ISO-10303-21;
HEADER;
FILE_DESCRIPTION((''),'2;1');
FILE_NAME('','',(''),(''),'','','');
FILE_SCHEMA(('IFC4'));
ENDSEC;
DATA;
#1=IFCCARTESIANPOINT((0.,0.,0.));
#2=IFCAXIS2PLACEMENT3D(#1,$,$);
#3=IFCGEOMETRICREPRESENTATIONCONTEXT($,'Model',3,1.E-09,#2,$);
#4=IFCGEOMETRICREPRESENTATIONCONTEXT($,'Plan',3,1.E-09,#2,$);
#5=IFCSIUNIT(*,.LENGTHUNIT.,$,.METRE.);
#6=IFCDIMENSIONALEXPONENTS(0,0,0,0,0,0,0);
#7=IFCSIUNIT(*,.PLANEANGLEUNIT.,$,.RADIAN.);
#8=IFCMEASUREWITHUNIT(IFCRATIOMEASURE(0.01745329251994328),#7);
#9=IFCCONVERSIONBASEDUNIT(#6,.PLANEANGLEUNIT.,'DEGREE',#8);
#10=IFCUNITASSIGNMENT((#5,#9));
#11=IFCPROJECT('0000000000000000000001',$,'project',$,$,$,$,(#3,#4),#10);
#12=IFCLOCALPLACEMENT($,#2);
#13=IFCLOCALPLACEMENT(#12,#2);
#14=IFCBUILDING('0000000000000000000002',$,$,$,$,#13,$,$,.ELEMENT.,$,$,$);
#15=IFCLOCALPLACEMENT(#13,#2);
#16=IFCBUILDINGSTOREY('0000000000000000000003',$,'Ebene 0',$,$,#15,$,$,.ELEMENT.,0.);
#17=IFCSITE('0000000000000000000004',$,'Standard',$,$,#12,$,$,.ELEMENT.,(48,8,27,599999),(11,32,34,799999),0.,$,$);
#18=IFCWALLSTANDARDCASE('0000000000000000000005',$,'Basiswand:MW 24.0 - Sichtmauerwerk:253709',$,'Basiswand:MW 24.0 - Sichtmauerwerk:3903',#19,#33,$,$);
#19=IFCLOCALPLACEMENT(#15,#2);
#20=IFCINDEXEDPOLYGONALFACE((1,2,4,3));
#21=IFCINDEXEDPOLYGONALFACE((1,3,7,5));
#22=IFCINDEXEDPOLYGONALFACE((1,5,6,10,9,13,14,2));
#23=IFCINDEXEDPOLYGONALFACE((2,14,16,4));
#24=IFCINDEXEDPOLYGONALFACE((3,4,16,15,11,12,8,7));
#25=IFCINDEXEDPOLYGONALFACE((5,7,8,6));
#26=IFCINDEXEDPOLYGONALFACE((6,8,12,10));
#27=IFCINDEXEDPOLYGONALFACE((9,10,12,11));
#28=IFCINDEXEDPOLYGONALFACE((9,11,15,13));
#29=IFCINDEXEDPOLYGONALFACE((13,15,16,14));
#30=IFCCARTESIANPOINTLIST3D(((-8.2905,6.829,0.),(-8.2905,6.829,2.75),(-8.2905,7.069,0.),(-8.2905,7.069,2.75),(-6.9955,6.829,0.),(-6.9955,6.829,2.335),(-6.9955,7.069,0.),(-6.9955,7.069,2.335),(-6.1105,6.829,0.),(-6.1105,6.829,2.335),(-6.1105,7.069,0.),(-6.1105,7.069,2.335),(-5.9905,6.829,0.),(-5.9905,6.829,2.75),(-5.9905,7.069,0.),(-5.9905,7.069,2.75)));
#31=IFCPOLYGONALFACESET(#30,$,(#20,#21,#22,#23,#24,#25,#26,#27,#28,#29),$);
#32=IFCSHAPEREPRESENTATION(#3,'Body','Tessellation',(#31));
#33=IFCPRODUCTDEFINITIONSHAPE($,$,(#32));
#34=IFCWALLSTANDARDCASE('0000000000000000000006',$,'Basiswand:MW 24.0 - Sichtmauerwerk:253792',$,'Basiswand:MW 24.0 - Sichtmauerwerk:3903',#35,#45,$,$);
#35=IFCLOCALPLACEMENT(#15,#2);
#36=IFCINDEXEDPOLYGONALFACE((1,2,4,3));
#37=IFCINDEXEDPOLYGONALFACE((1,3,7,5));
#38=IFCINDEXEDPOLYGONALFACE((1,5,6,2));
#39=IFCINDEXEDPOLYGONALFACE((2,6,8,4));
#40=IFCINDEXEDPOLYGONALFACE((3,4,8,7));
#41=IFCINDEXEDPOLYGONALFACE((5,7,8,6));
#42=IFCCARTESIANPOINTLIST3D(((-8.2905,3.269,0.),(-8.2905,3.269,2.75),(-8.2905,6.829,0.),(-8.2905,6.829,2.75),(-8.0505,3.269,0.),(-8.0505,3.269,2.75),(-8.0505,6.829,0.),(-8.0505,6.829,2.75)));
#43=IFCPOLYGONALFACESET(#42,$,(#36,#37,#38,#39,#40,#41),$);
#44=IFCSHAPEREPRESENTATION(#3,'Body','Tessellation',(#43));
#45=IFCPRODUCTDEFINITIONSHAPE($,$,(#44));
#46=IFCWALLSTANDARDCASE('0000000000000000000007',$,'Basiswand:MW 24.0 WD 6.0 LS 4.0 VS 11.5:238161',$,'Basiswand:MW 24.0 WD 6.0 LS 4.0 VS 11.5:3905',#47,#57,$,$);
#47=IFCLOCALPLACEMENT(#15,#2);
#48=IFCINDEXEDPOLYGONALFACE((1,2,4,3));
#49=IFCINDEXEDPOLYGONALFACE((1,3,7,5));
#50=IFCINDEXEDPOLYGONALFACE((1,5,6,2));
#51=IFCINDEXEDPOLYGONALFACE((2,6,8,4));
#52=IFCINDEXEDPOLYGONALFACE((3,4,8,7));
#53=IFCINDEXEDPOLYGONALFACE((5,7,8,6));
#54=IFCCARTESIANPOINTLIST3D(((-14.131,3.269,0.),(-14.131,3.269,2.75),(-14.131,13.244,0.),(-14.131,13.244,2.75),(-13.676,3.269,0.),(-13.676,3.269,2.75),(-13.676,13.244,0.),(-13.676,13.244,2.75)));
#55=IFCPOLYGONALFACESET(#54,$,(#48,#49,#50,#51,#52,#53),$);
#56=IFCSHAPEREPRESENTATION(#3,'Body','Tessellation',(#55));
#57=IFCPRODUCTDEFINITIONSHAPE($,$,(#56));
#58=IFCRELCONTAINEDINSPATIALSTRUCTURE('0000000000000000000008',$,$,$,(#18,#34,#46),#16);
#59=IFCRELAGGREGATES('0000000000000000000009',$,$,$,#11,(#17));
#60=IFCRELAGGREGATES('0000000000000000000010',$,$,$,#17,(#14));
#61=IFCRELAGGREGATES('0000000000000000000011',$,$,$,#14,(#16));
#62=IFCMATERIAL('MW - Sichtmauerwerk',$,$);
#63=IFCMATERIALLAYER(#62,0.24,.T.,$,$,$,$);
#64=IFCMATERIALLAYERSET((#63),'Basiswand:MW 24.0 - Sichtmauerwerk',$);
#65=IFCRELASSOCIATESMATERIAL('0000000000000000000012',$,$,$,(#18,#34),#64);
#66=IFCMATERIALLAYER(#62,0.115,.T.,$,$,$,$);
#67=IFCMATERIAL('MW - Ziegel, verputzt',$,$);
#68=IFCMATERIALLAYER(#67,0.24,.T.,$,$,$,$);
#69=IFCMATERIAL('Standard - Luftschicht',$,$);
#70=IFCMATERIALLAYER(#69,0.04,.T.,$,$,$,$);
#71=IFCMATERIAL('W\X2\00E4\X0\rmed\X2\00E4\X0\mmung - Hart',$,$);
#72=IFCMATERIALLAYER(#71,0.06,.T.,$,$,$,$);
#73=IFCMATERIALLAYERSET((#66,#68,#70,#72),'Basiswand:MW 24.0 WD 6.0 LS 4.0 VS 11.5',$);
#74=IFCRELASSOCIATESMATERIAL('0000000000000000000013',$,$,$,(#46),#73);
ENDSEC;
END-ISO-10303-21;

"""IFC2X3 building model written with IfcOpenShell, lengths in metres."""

from ifc_helpers import new_model, entity, si_unit, converted_unit, frame, frame_2d, origin, place, context, project, spatial, rectangle, extrude, material, layer, layer_set, layer_usage, element, save


model = new_model("IFC2X3")

# Units and contexts
model_context = context("Model", 3, precision=1e-09, world=origin())
plan_context = context("Plan", 3, precision=1e-09, world=origin())
ifc_project = project(units=[si_unit("LENGTHUNIT", "METRE"), converted_unit("PLANEANGLEUNIT", "DEGREE", entity("IfcRatioMeasure", 0.01745329251994328), si_unit("PLANEANGLEUNIT", "RADIAN"), dimensions=[0, 0, 0, 0, 0, 0, 0])], contexts=[model_context, plan_context])

# Site, building, storey
site_placement = place(None, origin())
site = spatial("IfcSite", under=ifc_project, at=site_placement, Name="Standard", CompositionType="ELEMENT", RefLatitude=(48, 8, 27, 599999), RefLongitude=(11, 32, 34, 799999), RefElevation=0.0)
building_placement = place(site_placement, origin())
building = spatial("IfcBuilding", under=site, at=building_placement, CompositionType="ELEMENT")
storey_placement = place(building_placement, origin())
storey = spatial("IfcBuildingStorey", under=building, at=storey_placement, Name="Ebene 0", CompositionType="ELEMENT", Elevation=0.0)

# Shared definitions
ifc_material_1 = material(Name="MW - Sichtmauerwerk")
ifc_layer_1 = layer(ifc_material_1, 0.24, ventilated=True)
ifc_layer_set_1 = layer_set([ifc_layer_1], Name="Basiswand:MW 24.0 - Sichtmauerwerk")

# Shared definitions
ifc_material_2 = material(Name="Wärmedämmung - Hart")

# Shared definitions
ifc_layer_2 = layer(ifc_material_1, 0.115, ventilated=True)
ifc_material_3 = material(Name="MW - Ziegel, verputzt")
ifc_layer_3 = layer(ifc_material_3, 0.24, ventilated=True)
ifc_material_4 = material(Name="Standard - Luftschicht")
ifc_layer_4 = layer(ifc_material_4, 0.04, ventilated=True)
ifc_layer_5 = layer(ifc_material_2, 0.06, ventilated=True)
ifc_layer_set_2 = layer_set([ifc_layer_2, ifc_layer_3, ifc_layer_4, ifc_layer_5], Name="Basiswand:MW 24.0 WD 6.0 LS 4.0 VS 11.5")

# Wall, opening
ifc_layer_usage_1 = layer_usage(ifc_layer_set_1, "AXIS2", "NEGATIVE", 0.12)
wall_1_placement = place(storey_placement, frame((-5.9905, 6.949, 0.0), z_axis=(0.0, 0.0, 1.0), x_axis=(-1.0, 0.0, 0.0)))
wall_1 = element("IfcWallStandardCase", 1, at=wall_1_placement, inside=storey, material=ifc_layer_usage_1, Name="Basiswand:MW 24.0 - Sichtmauerwerk:253709", ObjectType="Basiswand:MW 24.0 - Sichtmauerwerk:3903", context=model_context, shape_type="SweptSolid", body=[
    extrude(rectangle(XDim=2.3, YDim=0.24, at=frame_2d((1.15, 0.0), x_axis=(-1.0, 0.0))), origin(), (0.0, 0.0, 1.0), 2.75),
])
opening_1_placement = place(wall_1_placement, frame((1.005, 0.12, 0.0)))
element("IfcOpeningElement", 2, at=opening_1_placement, cuts=wall_1, ObjectType="Opening", context=model_context, shape_type="SweptSolid", body=[
    extrude(rectangle(XDim=2.335, YDim=0.885, at=frame_2d((1.1675, 0.4425), x_axis=(1.0, 0.0))), frame((0.0, 0.0, 0.0), z_axis=(0.0, -1.0, 0.0), x_axis=(0.0, 0.0, 1.0)), (0.0, 0.0, 1.0), 0.24),
])

# Wall
ifc_layer_usage_2 = layer_usage(ifc_layer_set_1, "AXIS2", "NEGATIVE", 0.12)
wall_2_placement = place(storey_placement, frame((-8.1705, 6.829, 0.0), z_axis=(0.0, 0.0, 1.0), x_axis=(0.0, -1.0, 0.0)))
element("IfcWallStandardCase", 3, at=wall_2_placement, inside=storey, material=ifc_layer_usage_2, Name="Basiswand:MW 24.0 - Sichtmauerwerk:253792", ObjectType="Basiswand:MW 24.0 - Sichtmauerwerk:3903", context=model_context, shape_type="SweptSolid", body=[
    extrude(rectangle(XDim=3.56, YDim=0.24, at=frame_2d((1.78, 0.0), x_axis=(-1.0, 0.0))), origin(), (0.0, 0.0, 1.0), 2.75),
])

# Wall
ifc_layer_usage_3 = layer_usage(ifc_layer_set_2, "AXIS2", "NEGATIVE", 0.2275)
wall_3_placement = place(storey_placement, frame((-13.9035, 3.269, 0.0), z_axis=(0.0, 0.0, 1.0), x_axis=(0.0, 1.0, 0.0)))
element("IfcWallStandardCase", 4, at=wall_3_placement, inside=storey, material=ifc_layer_usage_3, Name="Basiswand:MW 24.0 WD 6.0 LS 4.0 VS 11.5:238161", ObjectType="Basiswand:MW 24.0 WD 6.0 LS 4.0 VS 11.5:3905", context=model_context, shape_type="SweptSolid", body=[
    extrude(rectangle(XDim=9.975, YDim=0.455, at=frame_2d((4.9875, 0.0), x_axis=(-1.0, 0.0))), origin(), (0.0, 0.0, 1.0), 2.75),
])

save(model, "model.ifc")
